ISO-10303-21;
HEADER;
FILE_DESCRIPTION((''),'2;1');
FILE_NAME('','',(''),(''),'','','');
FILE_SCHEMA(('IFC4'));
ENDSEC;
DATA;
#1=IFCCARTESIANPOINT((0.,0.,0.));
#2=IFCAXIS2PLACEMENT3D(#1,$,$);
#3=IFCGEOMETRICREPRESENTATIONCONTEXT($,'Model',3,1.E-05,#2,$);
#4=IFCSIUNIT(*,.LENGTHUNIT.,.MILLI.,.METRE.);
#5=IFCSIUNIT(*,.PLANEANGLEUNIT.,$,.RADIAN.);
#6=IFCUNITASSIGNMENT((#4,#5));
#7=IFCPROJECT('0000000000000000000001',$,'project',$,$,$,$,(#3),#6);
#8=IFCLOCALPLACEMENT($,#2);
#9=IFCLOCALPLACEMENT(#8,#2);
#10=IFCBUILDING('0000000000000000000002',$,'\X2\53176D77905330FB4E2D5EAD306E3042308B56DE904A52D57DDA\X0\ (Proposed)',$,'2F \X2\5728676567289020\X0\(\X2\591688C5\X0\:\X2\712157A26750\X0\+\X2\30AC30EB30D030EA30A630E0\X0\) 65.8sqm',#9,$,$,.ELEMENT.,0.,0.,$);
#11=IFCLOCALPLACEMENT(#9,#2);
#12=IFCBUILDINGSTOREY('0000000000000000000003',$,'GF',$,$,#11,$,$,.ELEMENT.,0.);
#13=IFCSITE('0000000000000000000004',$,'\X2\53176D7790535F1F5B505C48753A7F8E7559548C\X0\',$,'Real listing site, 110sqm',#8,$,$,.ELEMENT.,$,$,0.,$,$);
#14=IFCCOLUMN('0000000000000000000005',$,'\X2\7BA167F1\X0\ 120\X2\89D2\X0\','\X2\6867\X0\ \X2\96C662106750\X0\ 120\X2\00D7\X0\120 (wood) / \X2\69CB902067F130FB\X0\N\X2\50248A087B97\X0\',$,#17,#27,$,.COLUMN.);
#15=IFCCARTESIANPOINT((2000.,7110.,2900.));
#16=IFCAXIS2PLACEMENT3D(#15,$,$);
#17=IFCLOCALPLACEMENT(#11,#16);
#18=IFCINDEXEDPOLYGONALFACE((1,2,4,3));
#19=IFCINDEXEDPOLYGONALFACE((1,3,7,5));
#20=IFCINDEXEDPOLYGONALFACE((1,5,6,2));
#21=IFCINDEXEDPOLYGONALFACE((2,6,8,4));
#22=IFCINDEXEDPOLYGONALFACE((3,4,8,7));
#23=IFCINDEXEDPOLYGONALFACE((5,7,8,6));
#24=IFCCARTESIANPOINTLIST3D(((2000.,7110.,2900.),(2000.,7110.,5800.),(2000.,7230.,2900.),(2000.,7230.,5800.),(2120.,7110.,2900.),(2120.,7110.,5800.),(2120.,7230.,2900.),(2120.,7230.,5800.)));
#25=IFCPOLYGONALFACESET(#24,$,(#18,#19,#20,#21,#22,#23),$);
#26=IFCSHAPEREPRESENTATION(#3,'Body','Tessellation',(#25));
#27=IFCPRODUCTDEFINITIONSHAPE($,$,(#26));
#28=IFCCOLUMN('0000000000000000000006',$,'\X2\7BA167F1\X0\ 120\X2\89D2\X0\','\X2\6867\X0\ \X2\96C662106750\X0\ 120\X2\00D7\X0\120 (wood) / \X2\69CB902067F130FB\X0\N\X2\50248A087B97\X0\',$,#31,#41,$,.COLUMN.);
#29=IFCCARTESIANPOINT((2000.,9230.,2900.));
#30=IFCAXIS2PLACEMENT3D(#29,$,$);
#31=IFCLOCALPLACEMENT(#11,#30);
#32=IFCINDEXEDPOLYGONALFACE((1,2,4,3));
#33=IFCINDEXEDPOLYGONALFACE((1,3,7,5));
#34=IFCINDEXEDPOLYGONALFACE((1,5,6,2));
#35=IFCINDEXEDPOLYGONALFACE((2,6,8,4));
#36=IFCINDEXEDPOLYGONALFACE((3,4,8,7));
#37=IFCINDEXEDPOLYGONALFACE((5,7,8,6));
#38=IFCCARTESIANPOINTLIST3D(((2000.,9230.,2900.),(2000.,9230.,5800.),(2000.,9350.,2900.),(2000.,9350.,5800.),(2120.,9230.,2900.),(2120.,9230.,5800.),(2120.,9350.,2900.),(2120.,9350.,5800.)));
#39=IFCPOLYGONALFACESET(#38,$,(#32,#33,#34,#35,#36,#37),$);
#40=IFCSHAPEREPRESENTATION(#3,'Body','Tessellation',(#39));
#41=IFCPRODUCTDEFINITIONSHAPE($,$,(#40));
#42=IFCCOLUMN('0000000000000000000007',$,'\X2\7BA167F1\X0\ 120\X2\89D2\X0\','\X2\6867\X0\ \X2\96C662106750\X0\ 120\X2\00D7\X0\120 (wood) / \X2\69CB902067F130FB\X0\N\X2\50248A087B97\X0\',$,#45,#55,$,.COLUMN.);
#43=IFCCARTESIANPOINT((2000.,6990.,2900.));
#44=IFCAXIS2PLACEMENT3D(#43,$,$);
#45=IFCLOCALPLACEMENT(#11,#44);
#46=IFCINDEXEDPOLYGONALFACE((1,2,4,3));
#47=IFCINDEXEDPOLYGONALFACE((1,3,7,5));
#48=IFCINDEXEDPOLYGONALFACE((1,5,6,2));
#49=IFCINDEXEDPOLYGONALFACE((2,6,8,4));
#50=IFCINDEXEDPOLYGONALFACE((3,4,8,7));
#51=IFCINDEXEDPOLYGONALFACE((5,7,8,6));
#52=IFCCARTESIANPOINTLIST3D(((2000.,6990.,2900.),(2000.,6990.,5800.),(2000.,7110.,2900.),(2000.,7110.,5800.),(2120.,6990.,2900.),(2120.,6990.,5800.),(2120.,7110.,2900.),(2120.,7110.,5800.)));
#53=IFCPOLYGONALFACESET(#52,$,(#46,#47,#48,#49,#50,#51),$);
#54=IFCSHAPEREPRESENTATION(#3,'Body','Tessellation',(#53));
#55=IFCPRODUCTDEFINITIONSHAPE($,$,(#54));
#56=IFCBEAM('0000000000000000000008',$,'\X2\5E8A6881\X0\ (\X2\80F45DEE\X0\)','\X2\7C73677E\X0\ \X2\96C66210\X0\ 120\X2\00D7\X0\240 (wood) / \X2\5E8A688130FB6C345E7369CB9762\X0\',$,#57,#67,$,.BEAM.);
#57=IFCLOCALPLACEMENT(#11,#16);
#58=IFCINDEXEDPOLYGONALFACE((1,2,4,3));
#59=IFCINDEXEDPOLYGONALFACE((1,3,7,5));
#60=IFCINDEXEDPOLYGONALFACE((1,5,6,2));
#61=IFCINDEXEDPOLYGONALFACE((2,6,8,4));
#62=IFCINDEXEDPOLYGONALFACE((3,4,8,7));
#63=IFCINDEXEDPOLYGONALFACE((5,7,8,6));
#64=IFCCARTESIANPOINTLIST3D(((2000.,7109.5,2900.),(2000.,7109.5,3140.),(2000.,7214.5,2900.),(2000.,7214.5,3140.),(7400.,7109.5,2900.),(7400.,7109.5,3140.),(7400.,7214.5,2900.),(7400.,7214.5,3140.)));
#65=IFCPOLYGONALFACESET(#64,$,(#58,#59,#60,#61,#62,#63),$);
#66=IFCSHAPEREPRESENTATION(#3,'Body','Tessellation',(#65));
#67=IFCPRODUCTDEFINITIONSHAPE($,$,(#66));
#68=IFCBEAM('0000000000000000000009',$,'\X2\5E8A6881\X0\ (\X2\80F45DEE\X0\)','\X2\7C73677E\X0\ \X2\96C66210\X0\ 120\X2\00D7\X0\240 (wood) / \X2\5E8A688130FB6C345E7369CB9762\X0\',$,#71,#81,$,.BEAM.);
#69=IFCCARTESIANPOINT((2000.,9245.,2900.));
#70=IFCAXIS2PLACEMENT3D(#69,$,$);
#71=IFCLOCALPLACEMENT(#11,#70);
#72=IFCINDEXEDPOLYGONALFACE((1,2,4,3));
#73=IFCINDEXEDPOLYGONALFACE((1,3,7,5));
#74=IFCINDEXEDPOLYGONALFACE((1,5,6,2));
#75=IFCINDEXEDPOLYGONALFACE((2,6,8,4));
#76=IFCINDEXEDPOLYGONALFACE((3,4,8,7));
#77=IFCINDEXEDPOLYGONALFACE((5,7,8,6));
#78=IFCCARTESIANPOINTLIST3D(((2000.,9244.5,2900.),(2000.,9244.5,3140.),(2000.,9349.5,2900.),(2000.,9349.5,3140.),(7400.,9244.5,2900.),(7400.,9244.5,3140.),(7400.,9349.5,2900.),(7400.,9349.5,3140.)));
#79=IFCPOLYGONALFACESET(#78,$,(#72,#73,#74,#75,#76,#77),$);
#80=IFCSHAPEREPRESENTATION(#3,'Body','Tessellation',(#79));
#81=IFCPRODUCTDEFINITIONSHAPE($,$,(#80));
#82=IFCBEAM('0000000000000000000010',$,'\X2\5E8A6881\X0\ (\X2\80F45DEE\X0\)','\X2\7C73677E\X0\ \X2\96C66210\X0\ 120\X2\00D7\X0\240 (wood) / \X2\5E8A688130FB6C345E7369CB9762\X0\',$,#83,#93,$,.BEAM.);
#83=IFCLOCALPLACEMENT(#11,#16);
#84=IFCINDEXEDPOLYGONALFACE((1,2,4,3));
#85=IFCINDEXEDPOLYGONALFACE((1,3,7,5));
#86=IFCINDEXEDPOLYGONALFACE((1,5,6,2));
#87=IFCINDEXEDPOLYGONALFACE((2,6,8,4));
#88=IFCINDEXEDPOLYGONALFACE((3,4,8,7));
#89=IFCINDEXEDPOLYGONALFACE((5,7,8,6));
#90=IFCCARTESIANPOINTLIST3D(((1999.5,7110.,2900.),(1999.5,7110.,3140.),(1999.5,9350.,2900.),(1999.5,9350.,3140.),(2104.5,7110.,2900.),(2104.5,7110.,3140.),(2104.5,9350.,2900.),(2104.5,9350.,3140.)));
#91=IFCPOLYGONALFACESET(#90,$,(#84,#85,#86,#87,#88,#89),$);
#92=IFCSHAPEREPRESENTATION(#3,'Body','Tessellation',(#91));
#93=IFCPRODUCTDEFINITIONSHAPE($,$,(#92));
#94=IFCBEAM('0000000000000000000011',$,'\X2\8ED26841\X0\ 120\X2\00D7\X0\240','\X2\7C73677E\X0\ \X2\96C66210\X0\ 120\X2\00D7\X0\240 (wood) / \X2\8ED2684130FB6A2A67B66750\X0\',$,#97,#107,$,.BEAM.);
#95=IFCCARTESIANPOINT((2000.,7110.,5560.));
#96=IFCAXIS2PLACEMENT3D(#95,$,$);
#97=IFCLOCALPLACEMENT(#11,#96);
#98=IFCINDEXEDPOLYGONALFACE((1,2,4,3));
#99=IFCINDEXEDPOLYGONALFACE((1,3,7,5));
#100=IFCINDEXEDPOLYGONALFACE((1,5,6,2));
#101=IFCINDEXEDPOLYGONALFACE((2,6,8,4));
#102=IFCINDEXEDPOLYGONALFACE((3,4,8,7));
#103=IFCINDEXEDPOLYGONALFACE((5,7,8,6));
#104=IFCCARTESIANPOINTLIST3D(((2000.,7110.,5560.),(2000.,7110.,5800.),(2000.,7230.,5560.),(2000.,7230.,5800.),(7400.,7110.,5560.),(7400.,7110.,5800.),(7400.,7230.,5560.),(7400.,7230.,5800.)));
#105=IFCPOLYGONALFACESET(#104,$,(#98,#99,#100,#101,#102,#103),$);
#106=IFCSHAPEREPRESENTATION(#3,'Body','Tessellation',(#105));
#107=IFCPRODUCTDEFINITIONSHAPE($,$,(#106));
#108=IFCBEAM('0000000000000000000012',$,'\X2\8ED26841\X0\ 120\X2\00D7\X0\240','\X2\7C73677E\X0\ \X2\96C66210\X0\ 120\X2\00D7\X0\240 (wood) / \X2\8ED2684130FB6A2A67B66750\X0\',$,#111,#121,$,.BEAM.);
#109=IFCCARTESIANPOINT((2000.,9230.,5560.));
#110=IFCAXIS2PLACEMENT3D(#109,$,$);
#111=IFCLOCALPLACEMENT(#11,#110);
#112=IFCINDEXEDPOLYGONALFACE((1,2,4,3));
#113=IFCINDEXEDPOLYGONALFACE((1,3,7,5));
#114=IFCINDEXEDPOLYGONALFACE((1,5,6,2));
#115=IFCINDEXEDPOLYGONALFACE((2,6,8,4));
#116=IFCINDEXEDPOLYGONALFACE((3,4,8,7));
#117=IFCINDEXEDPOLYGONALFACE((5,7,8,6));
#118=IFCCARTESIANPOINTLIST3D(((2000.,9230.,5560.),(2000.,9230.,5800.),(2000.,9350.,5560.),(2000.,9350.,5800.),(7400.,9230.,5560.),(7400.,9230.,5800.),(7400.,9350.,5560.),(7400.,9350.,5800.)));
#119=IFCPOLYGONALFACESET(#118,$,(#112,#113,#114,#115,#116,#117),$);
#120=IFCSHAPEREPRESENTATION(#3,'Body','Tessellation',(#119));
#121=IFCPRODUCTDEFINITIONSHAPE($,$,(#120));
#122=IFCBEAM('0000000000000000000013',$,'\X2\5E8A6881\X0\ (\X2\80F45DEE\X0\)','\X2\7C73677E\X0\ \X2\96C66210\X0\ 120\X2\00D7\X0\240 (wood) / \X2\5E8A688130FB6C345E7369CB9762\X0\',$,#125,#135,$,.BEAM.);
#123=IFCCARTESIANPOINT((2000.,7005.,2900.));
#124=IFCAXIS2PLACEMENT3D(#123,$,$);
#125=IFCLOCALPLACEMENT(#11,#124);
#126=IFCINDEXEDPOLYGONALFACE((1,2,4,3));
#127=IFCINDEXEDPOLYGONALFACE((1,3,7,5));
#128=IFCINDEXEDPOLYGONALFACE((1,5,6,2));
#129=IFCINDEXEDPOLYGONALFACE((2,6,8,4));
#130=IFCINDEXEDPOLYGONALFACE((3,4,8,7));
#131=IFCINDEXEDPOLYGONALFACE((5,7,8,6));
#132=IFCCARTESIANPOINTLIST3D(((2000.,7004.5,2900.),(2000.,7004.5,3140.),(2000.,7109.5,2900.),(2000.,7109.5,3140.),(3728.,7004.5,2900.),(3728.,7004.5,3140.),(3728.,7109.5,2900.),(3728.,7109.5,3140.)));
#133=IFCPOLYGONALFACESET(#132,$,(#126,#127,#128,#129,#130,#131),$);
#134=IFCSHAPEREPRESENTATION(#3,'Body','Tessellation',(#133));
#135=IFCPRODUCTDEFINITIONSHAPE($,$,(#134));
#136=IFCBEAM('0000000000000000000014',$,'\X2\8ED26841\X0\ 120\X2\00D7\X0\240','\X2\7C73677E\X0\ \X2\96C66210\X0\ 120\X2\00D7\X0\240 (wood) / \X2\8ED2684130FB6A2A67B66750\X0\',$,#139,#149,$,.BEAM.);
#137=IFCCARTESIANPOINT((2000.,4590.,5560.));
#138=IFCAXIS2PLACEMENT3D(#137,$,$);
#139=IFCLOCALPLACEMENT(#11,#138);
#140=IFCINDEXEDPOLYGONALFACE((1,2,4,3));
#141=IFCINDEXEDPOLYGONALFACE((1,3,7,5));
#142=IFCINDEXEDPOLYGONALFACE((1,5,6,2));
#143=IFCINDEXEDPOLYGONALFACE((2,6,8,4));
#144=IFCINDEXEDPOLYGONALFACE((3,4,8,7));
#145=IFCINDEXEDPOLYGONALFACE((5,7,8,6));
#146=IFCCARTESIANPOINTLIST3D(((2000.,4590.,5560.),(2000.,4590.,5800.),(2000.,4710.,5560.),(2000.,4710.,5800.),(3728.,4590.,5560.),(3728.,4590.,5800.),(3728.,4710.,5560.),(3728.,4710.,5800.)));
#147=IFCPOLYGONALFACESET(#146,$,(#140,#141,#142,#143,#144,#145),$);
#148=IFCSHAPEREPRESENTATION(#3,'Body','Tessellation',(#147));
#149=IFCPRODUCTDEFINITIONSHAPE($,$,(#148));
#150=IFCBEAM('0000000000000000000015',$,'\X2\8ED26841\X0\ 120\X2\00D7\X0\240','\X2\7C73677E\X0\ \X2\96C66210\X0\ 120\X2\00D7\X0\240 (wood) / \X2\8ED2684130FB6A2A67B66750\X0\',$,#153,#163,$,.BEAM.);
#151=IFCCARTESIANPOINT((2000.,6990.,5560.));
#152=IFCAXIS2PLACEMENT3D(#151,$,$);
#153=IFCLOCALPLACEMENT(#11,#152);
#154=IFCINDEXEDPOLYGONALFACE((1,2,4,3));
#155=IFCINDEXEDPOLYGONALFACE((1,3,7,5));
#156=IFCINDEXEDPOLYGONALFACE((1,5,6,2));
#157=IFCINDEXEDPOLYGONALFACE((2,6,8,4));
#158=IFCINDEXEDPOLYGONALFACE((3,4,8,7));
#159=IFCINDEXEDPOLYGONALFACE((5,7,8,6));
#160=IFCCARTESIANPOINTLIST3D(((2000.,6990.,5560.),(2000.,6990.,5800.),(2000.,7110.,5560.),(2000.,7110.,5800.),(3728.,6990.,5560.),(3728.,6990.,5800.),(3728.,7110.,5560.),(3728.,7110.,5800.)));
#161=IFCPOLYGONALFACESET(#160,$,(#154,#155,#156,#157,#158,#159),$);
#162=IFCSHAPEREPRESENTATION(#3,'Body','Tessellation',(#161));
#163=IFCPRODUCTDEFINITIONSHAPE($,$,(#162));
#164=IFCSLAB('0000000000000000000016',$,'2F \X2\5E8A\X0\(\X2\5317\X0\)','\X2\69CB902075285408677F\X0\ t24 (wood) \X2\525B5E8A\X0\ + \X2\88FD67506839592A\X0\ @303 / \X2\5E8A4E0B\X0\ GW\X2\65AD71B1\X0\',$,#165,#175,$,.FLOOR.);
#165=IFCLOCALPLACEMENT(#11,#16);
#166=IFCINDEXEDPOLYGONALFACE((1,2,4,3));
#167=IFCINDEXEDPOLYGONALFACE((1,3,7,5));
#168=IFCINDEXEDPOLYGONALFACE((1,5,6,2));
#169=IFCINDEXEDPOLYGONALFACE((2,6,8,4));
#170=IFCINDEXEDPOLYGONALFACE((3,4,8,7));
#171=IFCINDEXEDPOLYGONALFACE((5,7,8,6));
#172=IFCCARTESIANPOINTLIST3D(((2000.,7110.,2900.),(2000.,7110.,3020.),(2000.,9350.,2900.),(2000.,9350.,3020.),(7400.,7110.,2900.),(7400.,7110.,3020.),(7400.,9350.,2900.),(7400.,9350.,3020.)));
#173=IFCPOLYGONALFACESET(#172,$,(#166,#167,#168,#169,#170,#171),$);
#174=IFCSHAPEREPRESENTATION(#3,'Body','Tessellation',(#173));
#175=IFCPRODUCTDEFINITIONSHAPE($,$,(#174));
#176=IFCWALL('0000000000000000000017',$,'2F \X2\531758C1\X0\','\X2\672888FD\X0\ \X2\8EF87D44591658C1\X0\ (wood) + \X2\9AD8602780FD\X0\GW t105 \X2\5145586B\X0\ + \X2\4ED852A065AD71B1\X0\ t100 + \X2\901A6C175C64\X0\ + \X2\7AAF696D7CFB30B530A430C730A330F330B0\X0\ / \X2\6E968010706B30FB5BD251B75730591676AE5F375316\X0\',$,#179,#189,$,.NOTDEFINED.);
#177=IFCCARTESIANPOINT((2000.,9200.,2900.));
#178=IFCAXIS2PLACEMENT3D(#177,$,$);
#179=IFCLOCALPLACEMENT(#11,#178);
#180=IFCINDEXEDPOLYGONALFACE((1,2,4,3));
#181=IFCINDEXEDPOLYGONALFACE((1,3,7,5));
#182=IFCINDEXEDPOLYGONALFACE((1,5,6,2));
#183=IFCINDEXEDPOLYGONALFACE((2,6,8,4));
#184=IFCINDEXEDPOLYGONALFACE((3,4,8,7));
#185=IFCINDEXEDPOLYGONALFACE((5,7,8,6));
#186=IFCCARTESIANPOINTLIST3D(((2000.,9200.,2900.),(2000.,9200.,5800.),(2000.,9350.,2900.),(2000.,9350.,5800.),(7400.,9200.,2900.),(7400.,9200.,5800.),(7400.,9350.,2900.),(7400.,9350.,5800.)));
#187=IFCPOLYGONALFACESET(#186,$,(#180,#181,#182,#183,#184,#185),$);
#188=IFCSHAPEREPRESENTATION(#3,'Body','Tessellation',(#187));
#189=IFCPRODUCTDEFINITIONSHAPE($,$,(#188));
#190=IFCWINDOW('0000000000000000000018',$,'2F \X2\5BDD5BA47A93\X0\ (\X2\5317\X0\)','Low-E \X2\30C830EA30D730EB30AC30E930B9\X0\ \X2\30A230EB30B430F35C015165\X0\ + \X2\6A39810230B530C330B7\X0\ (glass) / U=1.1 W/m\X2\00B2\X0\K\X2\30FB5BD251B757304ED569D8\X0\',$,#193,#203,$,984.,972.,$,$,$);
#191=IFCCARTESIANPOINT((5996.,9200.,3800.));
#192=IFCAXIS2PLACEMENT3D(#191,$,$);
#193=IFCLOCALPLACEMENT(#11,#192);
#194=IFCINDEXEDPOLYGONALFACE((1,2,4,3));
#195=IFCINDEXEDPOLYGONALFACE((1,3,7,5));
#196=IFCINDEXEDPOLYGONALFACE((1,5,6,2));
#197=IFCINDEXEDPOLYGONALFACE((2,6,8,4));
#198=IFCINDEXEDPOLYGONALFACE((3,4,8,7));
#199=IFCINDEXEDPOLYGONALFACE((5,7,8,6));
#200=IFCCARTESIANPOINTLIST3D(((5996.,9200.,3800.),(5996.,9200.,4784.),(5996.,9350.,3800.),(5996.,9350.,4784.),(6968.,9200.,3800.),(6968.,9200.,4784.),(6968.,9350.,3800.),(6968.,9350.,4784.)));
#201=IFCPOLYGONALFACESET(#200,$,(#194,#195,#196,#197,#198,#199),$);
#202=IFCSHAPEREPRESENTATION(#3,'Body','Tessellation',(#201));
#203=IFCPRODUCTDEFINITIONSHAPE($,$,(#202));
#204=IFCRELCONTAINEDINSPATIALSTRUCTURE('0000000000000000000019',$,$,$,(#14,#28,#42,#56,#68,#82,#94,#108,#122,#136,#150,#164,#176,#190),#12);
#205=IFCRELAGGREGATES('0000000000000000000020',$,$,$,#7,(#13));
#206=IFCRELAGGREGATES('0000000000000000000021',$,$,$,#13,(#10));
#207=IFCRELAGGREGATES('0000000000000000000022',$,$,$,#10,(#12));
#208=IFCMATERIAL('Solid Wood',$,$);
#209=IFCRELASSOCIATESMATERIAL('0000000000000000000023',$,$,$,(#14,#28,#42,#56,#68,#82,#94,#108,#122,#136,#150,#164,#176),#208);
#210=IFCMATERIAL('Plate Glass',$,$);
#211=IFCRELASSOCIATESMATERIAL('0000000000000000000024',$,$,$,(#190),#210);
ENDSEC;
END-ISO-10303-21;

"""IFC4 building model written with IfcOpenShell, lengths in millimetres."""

from ifc_helpers import new_model, si_unit, frame, frame_2d, origin, place, context, project, spatial, rectangle, extrude, material, element, fill, save


model = new_model("IFC4")

# Units and contexts
model_context = context("Model", 3, precision=1e-05, world=origin())
ifc_project = project(units=[si_unit("LENGTHUNIT", "METRE", prefix="MILLI"), si_unit("PLANEANGLEUNIT", "RADIAN")], contexts=[model_context])

# Site, building, storey
site_placement = place(None, origin())
site = spatial("IfcSite", under=ifc_project, at=site_placement, Name="北海道弟子屈町美留和", ObjectType="Real listing site, 110sqm", CompositionType="ELEMENT", RefElevation=0.0)
building_placement = place(site_placement, origin())
building = spatial("IfcBuilding", under=site, at=building_placement, Name="北海道・中庭のある回遊動線 (Proposed)", ObjectType="2F 在来木造(外装:無垢材+ガルバリウム) 65.8sqm", CompositionType="ELEMENT", ElevationOfRefHeight=0.0, ElevationOfTerrain=0.0)
storey_placement = place(building_placement, origin())
storey = spatial("IfcBuildingStorey", under=building, at=storey_placement, Name="GF", CompositionType="ELEMENT", Elevation=0.0)

# Columns
ifc_material_1 = material(Name="Solid Wood")
column_1_placement = place(storey_placement, frame((2000.0, 7110.0, 2900.0)))
element("IfcColumn", 1, at=column_1_placement, inside=storey, material=ifc_material_1, Name="管柱 120角", Description="桧 集成材 120×120 (wood) / 構造柱・N値計算", PredefinedType="COLUMN", context=model_context, shape_type="SweptSolid", body=[
    extrude(rectangle(XDim=120.0, YDim=120.0, at=frame_2d((60.0, 60.0))), frame((2000.0, 7110.0, 2900.0)), (0.0, 0.0, 1.0), 2900.0),
])
column_2_placement = place(storey_placement, frame((2000.0, 9230.0, 2900.0)))
element("IfcColumn", 2, at=column_2_placement, inside=storey, material=ifc_material_1, Name="管柱 120角", Description="桧 集成材 120×120 (wood) / 構造柱・N値計算", PredefinedType="COLUMN", context=model_context, shape_type="SweptSolid", body=[
    extrude(rectangle(XDim=120.0, YDim=120.0, at=frame_2d((60.0, 60.0))), frame((2000.0, 9230.0, 2900.0)), (0.0, 0.0, 1.0), 2900.0),
])
column_3_placement = place(storey_placement, frame((2000.0, 6990.0, 2900.0)))
element("IfcColumn", 3, at=column_3_placement, inside=storey, material=ifc_material_1, Name="管柱 120角", Description="桧 集成材 120×120 (wood) / 構造柱・N値計算", PredefinedType="COLUMN", context=model_context, shape_type="SweptSolid", body=[
    extrude(rectangle(XDim=120.0, YDim=120.0, at=frame_2d((60.0, 60.0))), frame((2000.0, 6990.0, 2900.0)), (0.0, 0.0, 1.0), 2900.0),
])

# Beams
beam_1_placement = place(storey_placement, frame((2000.0, 7110.0, 2900.0)))
element("IfcBeam", 4, at=beam_1_placement, inside=storey, material=ifc_material_1, Name="床梁 (胴差)", Description="米松 集成 120×240 (wood) / 床梁・水平構面", PredefinedType="BEAM", context=model_context, shape_type="SweptSolid", body=[
    extrude(rectangle(XDim=5400.0, YDim=105.0, at=frame_2d((2700.0, 52.0))), frame((2000.0, 7110.0, 2900.0)), (0.0, 0.0, 1.0), 240.0),
])
beam_2_placement = place(storey_placement, frame((2000.0, 9245.0, 2900.0)))
element("IfcBeam", 5, at=beam_2_placement, inside=storey, material=ifc_material_1, Name="床梁 (胴差)", Description="米松 集成 120×240 (wood) / 床梁・水平構面", PredefinedType="BEAM", context=model_context, shape_type="SweptSolid", body=[
    extrude(rectangle(XDim=5400.0, YDim=105.0, at=frame_2d((2700.0, 52.0))), frame((2000.0, 9245.0, 2900.0)), (0.0, 0.0, 1.0), 240.0),
])
beam_3_placement = place(storey_placement, frame((2000.0, 7110.0, 2900.0)))
element("IfcBeam", 6, at=beam_3_placement, inside=storey, material=ifc_material_1, Name="床梁 (胴差)", Description="米松 集成 120×240 (wood) / 床梁・水平構面", PredefinedType="BEAM", context=model_context, shape_type="SweptSolid", body=[
    extrude(rectangle(XDim=105.0, YDim=2240.0, at=frame_2d((52.0, 1120.0))), frame((2000.0, 7110.0, 2900.0)), (0.0, 0.0, 1.0), 240.0),
])
beam_4_placement = place(storey_placement, frame((2000.0, 7110.0, 5560.0)))
element("IfcBeam", 7, at=beam_4_placement, inside=storey, material=ifc_material_1, Name="軒桁 120×240", Description="米松 集成 120×240 (wood) / 軒桁・横架材", PredefinedType="BEAM", context=model_context, shape_type="SweptSolid", body=[
    extrude(rectangle(XDim=5400.0, YDim=120.0, at=frame_2d((2700.0, 60.0))), frame((2000.0, 7110.0, 5560.0)), (0.0, 0.0, 1.0), 240.0),
])
beam_5_placement = place(storey_placement, frame((2000.0, 9230.0, 5560.0)))
element("IfcBeam", 8, at=beam_5_placement, inside=storey, material=ifc_material_1, Name="軒桁 120×240", Description="米松 集成 120×240 (wood) / 軒桁・横架材", PredefinedType="BEAM", context=model_context, shape_type="SweptSolid", body=[
    extrude(rectangle(XDim=5400.0, YDim=120.0, at=frame_2d((2700.0, 60.0))), frame((2000.0, 9230.0, 5560.0)), (0.0, 0.0, 1.0), 240.0),
])
beam_6_placement = place(storey_placement, frame((2000.0, 7005.0, 2900.0)))
element("IfcBeam", 9, at=beam_6_placement, inside=storey, material=ifc_material_1, Name="床梁 (胴差)", Description="米松 集成 120×240 (wood) / 床梁・水平構面", PredefinedType="BEAM", context=model_context, shape_type="SweptSolid", body=[
    extrude(rectangle(XDim=1728.0, YDim=105.0, at=frame_2d((864.0, 52.0))), frame((2000.0, 7005.0, 2900.0)), (0.0, 0.0, 1.0), 240.0),
])
beam_7_placement = place(storey_placement, frame((2000.0, 4590.0, 5560.0)))
element("IfcBeam", 10, at=beam_7_placement, inside=storey, material=ifc_material_1, Name="軒桁 120×240", Description="米松 集成 120×240 (wood) / 軒桁・横架材", PredefinedType="BEAM", context=model_context, shape_type="SweptSolid", body=[
    extrude(rectangle(XDim=1728.0, YDim=120.0, at=frame_2d((864.0, 60.0))), frame((2000.0, 4590.0, 5560.0)), (0.0, 0.0, 1.0), 240.0),
])
beam_8_placement = place(storey_placement, frame((2000.0, 6990.0, 5560.0)))
element("IfcBeam", 11, at=beam_8_placement, inside=storey, material=ifc_material_1, Name="軒桁 120×240", Description="米松 集成 120×240 (wood) / 軒桁・横架材", PredefinedType="BEAM", context=model_context, shape_type="SweptSolid", body=[
    extrude(rectangle(XDim=1728.0, YDim=120.0, at=frame_2d((864.0, 60.0))), frame((2000.0, 6990.0, 5560.0)), (0.0, 0.0, 1.0), 240.0),
])

# Slab
slab_placement = place(storey_placement, frame((2000.0, 7110.0, 2900.0)))
element("IfcSlab", 12, at=slab_placement, inside=storey, material=ifc_material_1, Name="2F 床(北)", Description="構造用合板 t24 (wood) 剛床 + 製材根太 @303 / 床下 GW断熱", PredefinedType="FLOOR", context=model_context, shape_type="SweptSolid", body=[
    extrude(rectangle(XDim=5400.0, YDim=2240.0, at=frame_2d((2700.0, 1120.0))), frame((2000.0, 7110.0, 2900.0)), (0.0, 0.0, 1.0), 120.0),
])

# Wall, opening, window
wall_placement = place(storey_placement, frame((2000.0, 9200.0, 2900.0)))
wall = element("IfcWall", 13, at=wall_placement, inside=storey, material=ifc_material_1, Name="2F 北壁", Description="木製 軸組外壁 (wood) + 高性能GW t105 充填 + 付加断熱 t100 + 通気層 + 窯業系サイディング / 準耐火・寒冷地外皮強化", PredefinedType="NOTDEFINED", context=model_context, shape_type="SweptSolid", body=[
    extrude(rectangle(XDim=5400.0, YDim=150.0, at=frame_2d((2700.0, 75.0))), frame((2000.0, 9200.0, 2900.0)), (0.0, 0.0, 1.0), 2900.0),
])
opening_placement = place(storey_placement, frame((5996.0, 9200.0, 3800.0)))
opening = element("IfcOpeningElement", 14, at=opening_placement, cuts=wall, PredefinedType="NOTDEFINED", context=model_context, shape_type="SweptSolid", body=[
    extrude(rectangle(XDim=972.0, YDim=150.0, at=frame_2d((486.0, 75.0))), frame((5996.0, 9200.0, 3800.0)), (0.0, 0.0, 1.0), 984.0),
])
ifc_material_2 = material(Name="Plate Glass")
window_placement = place(storey_placement, frame((5996.0, 9200.0, 3800.0)))
window = element("IfcWindow", 15, at=window_placement, inside=storey, material=ifc_material_2, Name="2F 寝室窓 (北)", Description="Low-E トリプルガラス アルゴン封入 + 樹脂サッシ (glass) / U=1.1 W/m²K・寒冷地仕様", OverallHeight=984.0, OverallWidth=972.0, context=model_context, shape_type="SweptSolid", body=[
    extrude(rectangle(XDim=972.0, YDim=150.0, at=frame_2d((486.0, 75.0))), frame((5996.0, 9200.0, 3800.0)), (0.0, 0.0, 1.0), 984.0),
])
fill(opening, window)

save(model, "model.ifc")
